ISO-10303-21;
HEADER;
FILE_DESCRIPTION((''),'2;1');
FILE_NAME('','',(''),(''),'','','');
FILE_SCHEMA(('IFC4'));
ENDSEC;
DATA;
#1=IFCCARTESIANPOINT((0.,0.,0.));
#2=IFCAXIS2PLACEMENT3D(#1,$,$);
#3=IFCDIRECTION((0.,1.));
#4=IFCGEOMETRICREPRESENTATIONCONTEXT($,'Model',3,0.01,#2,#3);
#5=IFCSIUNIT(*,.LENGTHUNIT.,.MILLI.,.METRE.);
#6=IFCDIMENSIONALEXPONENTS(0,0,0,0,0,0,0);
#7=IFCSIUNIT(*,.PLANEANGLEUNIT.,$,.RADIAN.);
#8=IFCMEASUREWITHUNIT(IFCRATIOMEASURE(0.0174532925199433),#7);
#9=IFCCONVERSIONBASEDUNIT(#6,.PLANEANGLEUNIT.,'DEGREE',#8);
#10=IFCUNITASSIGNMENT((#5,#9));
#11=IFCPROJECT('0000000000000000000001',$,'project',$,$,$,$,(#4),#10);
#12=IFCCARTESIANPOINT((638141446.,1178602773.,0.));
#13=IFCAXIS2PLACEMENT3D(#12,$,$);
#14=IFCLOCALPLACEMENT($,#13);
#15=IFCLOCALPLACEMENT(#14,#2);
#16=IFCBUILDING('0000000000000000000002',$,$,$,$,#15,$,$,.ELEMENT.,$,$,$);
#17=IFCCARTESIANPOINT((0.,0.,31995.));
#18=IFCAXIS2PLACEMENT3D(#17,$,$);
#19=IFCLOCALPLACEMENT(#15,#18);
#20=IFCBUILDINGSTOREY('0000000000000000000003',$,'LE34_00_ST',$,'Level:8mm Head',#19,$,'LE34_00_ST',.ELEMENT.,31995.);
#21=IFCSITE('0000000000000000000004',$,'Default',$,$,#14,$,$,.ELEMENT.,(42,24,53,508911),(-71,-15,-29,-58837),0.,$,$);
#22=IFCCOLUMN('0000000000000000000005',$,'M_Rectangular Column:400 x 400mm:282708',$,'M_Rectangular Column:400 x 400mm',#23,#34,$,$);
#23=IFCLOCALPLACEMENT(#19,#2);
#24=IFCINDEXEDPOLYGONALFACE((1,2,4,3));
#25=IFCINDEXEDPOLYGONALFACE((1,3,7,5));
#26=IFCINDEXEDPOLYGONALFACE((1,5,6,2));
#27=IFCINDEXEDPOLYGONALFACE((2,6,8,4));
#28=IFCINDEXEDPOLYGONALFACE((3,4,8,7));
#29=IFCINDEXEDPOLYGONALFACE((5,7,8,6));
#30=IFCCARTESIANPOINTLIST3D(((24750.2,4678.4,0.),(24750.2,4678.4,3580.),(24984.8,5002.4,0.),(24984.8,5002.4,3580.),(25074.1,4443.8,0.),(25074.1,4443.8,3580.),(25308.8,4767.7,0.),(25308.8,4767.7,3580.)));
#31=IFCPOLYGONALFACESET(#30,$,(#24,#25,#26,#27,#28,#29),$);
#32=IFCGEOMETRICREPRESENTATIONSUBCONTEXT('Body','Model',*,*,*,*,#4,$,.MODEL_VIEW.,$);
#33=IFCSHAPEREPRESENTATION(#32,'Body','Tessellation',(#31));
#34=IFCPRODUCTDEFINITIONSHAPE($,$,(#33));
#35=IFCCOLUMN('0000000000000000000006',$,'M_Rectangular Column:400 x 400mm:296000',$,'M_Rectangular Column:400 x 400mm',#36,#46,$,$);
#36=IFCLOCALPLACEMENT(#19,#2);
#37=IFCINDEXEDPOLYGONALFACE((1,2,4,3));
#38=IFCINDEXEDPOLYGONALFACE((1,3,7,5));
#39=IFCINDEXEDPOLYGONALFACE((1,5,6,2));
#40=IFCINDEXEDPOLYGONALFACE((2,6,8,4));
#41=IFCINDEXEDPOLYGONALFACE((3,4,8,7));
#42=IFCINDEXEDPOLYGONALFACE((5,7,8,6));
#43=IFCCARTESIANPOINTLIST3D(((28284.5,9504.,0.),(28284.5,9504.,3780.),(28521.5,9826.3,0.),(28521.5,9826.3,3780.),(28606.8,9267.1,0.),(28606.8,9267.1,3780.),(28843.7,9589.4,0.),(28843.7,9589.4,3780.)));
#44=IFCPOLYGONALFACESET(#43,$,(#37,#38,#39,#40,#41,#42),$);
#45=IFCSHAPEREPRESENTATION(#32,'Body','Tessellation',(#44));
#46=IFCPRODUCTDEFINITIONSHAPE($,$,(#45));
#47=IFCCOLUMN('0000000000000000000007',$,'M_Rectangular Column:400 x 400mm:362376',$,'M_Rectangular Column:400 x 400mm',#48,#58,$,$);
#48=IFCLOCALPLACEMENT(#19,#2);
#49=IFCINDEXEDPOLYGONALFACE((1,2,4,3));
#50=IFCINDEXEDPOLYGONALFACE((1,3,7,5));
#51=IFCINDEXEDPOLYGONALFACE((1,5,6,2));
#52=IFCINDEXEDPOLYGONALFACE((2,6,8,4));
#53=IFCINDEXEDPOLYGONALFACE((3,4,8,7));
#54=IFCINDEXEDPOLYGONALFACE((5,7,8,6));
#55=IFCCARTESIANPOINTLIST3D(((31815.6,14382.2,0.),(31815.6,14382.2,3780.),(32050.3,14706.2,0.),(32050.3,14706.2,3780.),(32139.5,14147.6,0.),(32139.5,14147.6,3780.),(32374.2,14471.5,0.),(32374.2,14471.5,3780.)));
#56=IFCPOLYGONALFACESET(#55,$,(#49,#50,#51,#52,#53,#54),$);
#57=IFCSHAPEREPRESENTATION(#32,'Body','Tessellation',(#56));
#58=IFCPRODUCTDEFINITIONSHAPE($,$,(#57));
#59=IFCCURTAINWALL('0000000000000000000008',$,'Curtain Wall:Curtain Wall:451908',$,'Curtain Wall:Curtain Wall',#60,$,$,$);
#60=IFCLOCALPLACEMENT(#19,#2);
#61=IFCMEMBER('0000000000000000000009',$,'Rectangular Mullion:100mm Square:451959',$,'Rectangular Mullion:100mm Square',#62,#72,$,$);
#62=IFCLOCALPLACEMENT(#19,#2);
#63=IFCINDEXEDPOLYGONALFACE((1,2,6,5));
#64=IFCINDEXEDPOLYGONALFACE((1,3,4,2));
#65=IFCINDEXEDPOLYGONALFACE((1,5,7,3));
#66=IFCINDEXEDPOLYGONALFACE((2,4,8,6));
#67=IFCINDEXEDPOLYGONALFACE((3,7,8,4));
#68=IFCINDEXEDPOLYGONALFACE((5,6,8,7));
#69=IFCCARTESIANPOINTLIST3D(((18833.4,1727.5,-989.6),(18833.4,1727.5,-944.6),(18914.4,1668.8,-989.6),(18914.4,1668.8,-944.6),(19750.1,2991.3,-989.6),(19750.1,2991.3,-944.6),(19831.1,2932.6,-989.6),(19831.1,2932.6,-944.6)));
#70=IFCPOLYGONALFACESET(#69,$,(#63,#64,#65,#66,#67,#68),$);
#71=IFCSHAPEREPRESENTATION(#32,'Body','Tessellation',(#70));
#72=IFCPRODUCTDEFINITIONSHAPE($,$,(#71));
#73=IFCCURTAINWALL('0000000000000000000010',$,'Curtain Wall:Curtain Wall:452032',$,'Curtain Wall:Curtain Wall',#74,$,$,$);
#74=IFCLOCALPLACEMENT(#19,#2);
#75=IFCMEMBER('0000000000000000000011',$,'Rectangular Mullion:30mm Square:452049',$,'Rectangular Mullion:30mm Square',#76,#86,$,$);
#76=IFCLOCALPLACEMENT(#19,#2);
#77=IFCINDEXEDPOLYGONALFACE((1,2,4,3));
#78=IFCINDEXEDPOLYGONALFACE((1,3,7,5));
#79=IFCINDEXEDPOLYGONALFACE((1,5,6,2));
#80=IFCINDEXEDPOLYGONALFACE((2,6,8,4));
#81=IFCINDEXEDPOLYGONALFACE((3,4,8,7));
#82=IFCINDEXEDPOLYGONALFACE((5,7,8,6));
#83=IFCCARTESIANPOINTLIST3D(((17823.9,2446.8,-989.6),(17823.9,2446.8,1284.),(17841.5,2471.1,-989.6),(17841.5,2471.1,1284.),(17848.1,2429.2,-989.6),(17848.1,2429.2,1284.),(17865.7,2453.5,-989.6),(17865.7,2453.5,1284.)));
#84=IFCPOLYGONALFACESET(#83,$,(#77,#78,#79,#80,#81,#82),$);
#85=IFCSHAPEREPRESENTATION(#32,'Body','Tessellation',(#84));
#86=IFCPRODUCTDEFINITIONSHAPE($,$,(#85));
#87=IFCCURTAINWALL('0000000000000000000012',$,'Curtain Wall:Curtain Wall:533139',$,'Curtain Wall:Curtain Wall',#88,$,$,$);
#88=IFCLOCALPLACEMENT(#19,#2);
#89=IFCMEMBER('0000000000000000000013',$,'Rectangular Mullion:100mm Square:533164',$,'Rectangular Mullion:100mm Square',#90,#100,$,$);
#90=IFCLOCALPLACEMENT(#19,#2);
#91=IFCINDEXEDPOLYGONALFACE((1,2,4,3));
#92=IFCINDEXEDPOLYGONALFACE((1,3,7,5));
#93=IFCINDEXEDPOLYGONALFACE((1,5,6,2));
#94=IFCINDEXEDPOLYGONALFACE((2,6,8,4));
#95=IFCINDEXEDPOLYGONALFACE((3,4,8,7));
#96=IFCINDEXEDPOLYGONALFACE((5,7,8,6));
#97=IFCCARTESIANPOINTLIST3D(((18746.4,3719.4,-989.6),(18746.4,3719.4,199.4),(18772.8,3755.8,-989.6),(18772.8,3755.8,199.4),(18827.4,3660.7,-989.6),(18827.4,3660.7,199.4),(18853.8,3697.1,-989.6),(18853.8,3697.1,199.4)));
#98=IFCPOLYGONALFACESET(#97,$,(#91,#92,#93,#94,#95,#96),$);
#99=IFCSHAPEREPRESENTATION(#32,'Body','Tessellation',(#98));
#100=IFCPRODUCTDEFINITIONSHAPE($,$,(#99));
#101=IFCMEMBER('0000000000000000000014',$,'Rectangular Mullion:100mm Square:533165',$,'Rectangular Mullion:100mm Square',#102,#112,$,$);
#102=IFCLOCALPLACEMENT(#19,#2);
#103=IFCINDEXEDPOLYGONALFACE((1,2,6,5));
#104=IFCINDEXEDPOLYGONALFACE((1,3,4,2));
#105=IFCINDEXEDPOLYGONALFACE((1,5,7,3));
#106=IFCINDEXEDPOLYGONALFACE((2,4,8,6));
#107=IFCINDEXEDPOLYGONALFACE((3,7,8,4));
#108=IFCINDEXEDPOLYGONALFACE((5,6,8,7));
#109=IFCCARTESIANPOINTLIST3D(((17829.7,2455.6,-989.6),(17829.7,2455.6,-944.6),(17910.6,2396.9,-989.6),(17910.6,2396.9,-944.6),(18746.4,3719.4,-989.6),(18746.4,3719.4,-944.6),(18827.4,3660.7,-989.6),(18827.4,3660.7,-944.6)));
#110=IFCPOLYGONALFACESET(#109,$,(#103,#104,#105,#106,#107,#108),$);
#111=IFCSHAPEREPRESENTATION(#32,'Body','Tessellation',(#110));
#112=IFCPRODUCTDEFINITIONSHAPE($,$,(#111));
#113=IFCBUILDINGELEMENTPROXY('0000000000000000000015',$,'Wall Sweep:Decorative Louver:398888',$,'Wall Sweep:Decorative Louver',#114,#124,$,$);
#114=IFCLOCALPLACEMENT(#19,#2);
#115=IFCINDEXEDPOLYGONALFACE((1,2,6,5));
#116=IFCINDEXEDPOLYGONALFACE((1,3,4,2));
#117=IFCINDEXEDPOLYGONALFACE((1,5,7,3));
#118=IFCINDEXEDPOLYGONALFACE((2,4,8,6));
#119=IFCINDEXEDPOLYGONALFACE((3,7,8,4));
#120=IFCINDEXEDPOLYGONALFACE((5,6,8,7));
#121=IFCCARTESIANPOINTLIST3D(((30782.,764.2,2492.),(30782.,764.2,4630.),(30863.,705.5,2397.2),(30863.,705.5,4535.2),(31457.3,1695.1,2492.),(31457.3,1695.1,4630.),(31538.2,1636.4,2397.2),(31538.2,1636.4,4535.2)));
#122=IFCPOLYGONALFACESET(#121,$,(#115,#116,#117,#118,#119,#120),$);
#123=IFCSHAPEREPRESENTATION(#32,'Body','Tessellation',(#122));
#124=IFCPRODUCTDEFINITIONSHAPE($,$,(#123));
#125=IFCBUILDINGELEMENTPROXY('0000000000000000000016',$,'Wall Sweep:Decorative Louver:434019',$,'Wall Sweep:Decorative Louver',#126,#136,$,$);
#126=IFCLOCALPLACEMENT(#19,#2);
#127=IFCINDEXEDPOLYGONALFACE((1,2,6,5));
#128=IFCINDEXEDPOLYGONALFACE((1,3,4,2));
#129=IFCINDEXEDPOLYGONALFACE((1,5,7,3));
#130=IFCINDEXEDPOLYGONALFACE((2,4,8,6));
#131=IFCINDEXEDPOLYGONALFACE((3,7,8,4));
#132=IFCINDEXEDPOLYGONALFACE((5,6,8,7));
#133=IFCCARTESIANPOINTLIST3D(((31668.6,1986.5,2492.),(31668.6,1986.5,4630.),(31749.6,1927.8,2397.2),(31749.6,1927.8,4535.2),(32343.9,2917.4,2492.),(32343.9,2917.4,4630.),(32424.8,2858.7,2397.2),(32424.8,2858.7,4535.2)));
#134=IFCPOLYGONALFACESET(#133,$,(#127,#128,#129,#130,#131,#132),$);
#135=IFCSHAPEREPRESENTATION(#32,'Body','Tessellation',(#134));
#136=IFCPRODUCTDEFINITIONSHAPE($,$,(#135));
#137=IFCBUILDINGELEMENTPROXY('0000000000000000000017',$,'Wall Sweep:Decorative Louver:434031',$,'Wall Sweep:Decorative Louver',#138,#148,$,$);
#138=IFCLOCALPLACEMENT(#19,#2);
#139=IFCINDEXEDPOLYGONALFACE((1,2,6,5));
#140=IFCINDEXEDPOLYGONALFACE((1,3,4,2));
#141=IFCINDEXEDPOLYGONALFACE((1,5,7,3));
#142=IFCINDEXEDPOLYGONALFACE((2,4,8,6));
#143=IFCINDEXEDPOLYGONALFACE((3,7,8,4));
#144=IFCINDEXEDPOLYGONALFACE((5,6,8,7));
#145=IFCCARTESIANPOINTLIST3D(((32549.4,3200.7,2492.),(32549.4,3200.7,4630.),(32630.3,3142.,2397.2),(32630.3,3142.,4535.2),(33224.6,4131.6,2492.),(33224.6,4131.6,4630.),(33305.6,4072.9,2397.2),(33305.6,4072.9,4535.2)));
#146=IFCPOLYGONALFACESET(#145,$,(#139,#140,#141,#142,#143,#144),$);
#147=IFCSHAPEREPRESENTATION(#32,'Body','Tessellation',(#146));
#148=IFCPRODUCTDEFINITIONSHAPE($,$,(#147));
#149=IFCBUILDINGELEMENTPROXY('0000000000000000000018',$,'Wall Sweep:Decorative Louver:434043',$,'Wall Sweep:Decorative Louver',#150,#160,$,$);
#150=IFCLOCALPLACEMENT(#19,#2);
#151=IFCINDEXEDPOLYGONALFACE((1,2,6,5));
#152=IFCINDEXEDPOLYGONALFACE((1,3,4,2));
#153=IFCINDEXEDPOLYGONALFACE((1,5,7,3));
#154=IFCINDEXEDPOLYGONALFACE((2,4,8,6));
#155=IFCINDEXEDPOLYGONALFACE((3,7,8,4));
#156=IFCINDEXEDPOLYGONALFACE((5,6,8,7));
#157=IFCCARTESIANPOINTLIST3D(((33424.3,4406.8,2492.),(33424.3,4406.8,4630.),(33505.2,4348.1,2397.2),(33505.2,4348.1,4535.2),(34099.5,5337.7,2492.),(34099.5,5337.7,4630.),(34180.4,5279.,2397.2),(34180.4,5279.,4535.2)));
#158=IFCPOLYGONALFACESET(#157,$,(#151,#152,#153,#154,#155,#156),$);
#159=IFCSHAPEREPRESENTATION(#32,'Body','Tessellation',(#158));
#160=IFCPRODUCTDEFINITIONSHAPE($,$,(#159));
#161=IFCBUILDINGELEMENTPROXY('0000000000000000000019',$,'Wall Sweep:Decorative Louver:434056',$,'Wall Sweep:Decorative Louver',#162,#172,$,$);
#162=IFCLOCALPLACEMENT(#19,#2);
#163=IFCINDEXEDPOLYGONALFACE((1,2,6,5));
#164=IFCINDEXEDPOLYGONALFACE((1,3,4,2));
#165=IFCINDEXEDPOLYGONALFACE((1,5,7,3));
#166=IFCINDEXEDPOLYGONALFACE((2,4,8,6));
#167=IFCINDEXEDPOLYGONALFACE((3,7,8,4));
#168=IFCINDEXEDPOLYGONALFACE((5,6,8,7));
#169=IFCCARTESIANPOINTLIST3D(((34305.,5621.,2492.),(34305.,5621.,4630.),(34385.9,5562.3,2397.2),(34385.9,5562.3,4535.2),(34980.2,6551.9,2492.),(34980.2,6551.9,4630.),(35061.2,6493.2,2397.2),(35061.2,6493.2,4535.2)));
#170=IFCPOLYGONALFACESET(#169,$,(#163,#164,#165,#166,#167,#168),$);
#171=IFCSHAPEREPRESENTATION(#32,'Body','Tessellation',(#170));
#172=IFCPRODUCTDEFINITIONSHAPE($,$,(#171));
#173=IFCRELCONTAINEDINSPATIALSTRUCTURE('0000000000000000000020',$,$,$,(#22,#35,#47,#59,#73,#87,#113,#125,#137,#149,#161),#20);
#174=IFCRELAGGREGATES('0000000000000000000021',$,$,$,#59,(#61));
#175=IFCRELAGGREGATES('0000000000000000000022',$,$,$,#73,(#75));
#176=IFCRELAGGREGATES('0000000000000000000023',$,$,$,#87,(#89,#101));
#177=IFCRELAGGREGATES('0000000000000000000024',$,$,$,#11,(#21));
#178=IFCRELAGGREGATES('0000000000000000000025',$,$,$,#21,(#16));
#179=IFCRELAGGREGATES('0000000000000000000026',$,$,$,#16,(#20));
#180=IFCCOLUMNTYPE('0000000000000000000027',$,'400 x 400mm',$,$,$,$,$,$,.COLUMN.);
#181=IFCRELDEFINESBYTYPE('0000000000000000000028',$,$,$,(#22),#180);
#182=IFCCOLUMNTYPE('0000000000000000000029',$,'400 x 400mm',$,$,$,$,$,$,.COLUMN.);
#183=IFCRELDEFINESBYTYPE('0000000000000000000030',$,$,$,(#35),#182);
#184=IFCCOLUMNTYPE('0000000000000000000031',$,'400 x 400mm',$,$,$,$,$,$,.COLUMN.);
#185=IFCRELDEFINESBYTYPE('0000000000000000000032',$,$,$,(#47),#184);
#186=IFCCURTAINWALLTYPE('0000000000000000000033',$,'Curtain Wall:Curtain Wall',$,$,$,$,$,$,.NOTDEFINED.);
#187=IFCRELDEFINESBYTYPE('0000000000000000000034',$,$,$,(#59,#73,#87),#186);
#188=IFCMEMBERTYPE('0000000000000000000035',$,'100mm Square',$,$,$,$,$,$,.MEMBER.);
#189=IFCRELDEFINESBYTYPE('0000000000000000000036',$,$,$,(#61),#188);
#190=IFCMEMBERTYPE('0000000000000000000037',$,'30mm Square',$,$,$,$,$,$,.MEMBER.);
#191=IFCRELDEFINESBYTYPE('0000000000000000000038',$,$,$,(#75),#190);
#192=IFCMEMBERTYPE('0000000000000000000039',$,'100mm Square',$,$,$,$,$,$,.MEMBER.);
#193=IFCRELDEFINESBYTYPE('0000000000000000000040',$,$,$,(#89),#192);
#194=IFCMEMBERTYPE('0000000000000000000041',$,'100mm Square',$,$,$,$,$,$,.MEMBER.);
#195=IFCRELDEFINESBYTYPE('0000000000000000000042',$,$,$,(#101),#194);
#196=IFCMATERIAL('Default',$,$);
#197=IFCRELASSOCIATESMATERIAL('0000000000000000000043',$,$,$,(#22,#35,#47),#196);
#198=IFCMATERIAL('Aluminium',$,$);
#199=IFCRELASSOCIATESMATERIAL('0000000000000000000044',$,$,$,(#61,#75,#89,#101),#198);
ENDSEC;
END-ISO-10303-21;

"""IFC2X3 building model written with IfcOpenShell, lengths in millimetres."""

from ifc_helpers import new_model, entity, si_unit, converted_unit, direction, frame, frame_2d, origin, origin_2d_with_axis, place, context, subcontext, project, spatial, polyline, rectangle, outline, extrude, source, transform, mapped, material, type_object, type_shapes, element, aggregate, save


model = new_model("IFC2X3")

# Units and contexts
model_context = context("Model", 3, precision=0.01, world=origin(), true_north=direction((0.0, 1.0)))
body_context = subcontext(model_context, "Body", "Model", "MODEL_VIEW")
ifc_project = project(units=[si_unit("LENGTHUNIT", "METRE", prefix="MILLI"), converted_unit("PLANEANGLEUNIT", "DEGREE", entity("IfcRatioMeasure", 0.0174532925199433), si_unit("PLANEANGLEUNIT", "RADIAN"), dimensions=[0, 0, 0, 0, 0, 0, 0])], contexts=[model_context])

# Site, building, storey
site_placement = place(None, frame((638141446.0, 1178602773.0, 0.0)))
site = spatial("IfcSite", under=ifc_project, at=site_placement, Name="Default", CompositionType="ELEMENT", RefLatitude=(42, 24, 53, 508911), RefLongitude=(-71, -15, -29, -58837), RefElevation=0.0)
building_placement = place(site_placement, origin())
building = spatial("IfcBuilding", under=site, at=building_placement, CompositionType="ELEMENT")
storey_placement = place(building_placement, frame((0.0, 0.0, 31995.0)))
storey = spatial("IfcBuildingStorey", under=building, at=storey_placement, Name="LE34_00_ST", ObjectType="Level:8mm Head", LongName="LE34_00_ST", CompositionType="ELEMENT", Elevation=31995.0)

# Columns
ifc_material_1 = material(Name="Default")
column_type_1 = type_object("IfcColumnType", Name="400 x 400mm", PredefinedType="COLUMN")
shared_shape_1 = source(origin(), body_context, "Body", "SweptSolid", [
    extrude(rectangle(XDim=400.0, YDim=400.0, at=frame_2d((0.0, 0.0), x_axis=(1.0, 0.0))), frame((25029.5, 4723.1, 31995.0), z_axis=(0.0, 0.0, 1.0), x_axis=(-0.809827, 0.586669, 0.0)), (0.0, 0.0, 1.0), 3580.0),
])
type_shapes(column_type_1, [shared_shape_1])
column_1_placement = place(storey_placement, frame((0.0, 0.0, -31995.0)))
element("IfcColumn", 1, at=column_1_placement, inside=storey, type_object=column_type_1, material=ifc_material_1, Name="M_Rectangular Column:400 x 400mm:282708", ObjectType="M_Rectangular Column:400 x 400mm", context=body_context, shape_type="MappedRepresentation", body=[
    mapped(shared_shape_1, transform((0.0, 0.0, 0.0), scale=1.0)),
])
column_type_2 = type_object("IfcColumnType", Name="400 x 400mm", PredefinedType="COLUMN")
shared_shape_2 = source(origin(), body_context, "Body", "SweptSolid", [
    extrude(rectangle(XDim=400.0, YDim=400.0, at=frame_2d((0.0, 0.0), x_axis=(1.0, 0.0))), frame((28564.1, 9546.7, 31995.0), z_axis=(0.0, 0.0, 1.0), x_axis=(-0.805709, 0.592312, 0.0)), (0.0, 0.0, 1.0), 3780.0),
])
type_shapes(column_type_2, [shared_shape_2])
column_2_placement = place(storey_placement, frame((0.0, 0.0, -31995.0)))
element("IfcColumn", 2, at=column_2_placement, inside=storey, type_object=column_type_2, material=ifc_material_1, Name="M_Rectangular Column:400 x 400mm:296000", ObjectType="M_Rectangular Column:400 x 400mm", context=body_context, shape_type="MappedRepresentation", body=[
    mapped(shared_shape_2, transform((0.0, 0.0, 0.0), scale=1.0)),
])
column_type_3 = type_object("IfcColumnType", Name="400 x 400mm", PredefinedType="COLUMN")
shared_shape_3 = source(origin(), body_context, "Body", "SweptSolid", [
    extrude(rectangle(XDim=400.0, YDim=400.0, at=frame_2d((0.0, 0.0), x_axis=(1.0, 0.0))), frame((32094.9, 14426.9, 31995.0), z_axis=(0.0, 0.0, 1.0), x_axis=(-0.809804, 0.5867, 0.0)), (0.0, 0.0, 1.0), 3780.0),
])
type_shapes(column_type_3, [shared_shape_3])
column_3_placement = place(storey_placement, frame((0.0, 0.0, -31995.0)))
element("IfcColumn", 3, at=column_3_placement, inside=storey, type_object=column_type_3, material=ifc_material_1, Name="M_Rectangular Column:400 x 400mm:362376", ObjectType="M_Rectangular Column:400 x 400mm", context=body_context, shape_type="MappedRepresentation", body=[
    mapped(shared_shape_3, transform((0.0, 0.0, 0.0), scale=1.0)),
])

# Curtain walls, members
curtain_wall_type = type_object("IfcCurtainWallType", Name="Curtain Wall:Curtain Wall", PredefinedType="NOTDEFINED")
curtain_wall_1_placement = place(storey_placement, frame((0.0, 0.0, -31995.0)))
curtain_wall_1 = element("IfcCurtainWall", 4, at=curtain_wall_1_placement, inside=storey, type_object=curtain_wall_type, Name="Curtain Wall:Curtain Wall:451908", ObjectType="Curtain Wall:Curtain Wall")
ifc_material_2 = material(Name="Aluminium")
member_type_1 = type_object("IfcMemberType", Name="100mm Square", PredefinedType="MEMBER")
shared_shape_4 = source(origin(), body_context, "Body", "SweptSolid", [
    extrude(rectangle(XDim=100.0, YDim=45.0, at=origin_2d_with_axis()), frame((-22.5, 0.0, -1561.3), z_axis=(0.0, 0.0, 1.0), x_axis=(0.0, -1.0, 0.0)), (0.0, 0.0, 1.0), 1561.3),
])
type_shapes(member_type_1, [shared_shape_4])
member_1_placement = place(storey_placement, frame((18873.9, 1698.1, -989.6), z_axis=(-0.587164, -0.809468, 0.0), x_axis=(0.0, 0.0, -1.0)))
member_1 = element("IfcMember", 5, at=member_1_placement, type_object=member_type_1, material=ifc_material_2, Name="Rectangular Mullion:100mm Square:451959", ObjectType="Rectangular Mullion:100mm Square", context=body_context, shape_type="MappedRepresentation", body=[
    mapped(shared_shape_4, transform((0.0, 0.0, 0.0), scale=1.0)),
])
aggregate(curtain_wall_1, [member_1])
curtain_wall_2_placement = place(storey_placement, frame((0.0, 0.0, -31995.0)))
curtain_wall_2 = element("IfcCurtainWall", 6, at=curtain_wall_2_placement, inside=storey, type_object=curtain_wall_type, Name="Curtain Wall:Curtain Wall:452032", ObjectType="Curtain Wall:Curtain Wall")
member_type_2 = type_object("IfcMemberType", Name="30mm Square", PredefinedType="MEMBER")
shared_shape_5 = source(origin(), body_context, "Body", "SweptSolid", [
    extrude(rectangle(XDim=30.0, YDim=30.0, at=origin_2d_with_axis()), frame((-15.0, 0.0, -2273.6), z_axis=(0.0, 0.0, 1.0), x_axis=(0.0, -1.0, 0.0)), (0.0, 0.0, 1.0), 2273.6),
])
type_shapes(member_type_2, [shared_shape_5])
member_2_placement = place(storey_placement, frame((17832.7, 2459.0, -989.6), z_axis=(0.0, 0.0, -1.0), x_axis=(-0.809468, 0.587164, 0.0)))
member_2 = element("IfcMember", 7, at=member_2_placement, type_object=member_type_2, material=ifc_material_2, Name="Rectangular Mullion:30mm Square:452049", ObjectType="Rectangular Mullion:30mm Square", context=body_context, shape_type="MappedRepresentation", body=[
    mapped(shared_shape_5, transform((0.0, 0.0, 0.0), scale=1.0)),
])

# Curtain wall, members
curtain_wall_3_placement = place(storey_placement, frame((0.0, 0.0, -31995.0)))
curtain_wall_3 = element("IfcCurtainWall", 8, at=curtain_wall_3_placement, inside=storey, type_object=curtain_wall_type, Name="Curtain Wall:Curtain Wall:533139", ObjectType="Curtain Wall:Curtain Wall")
member_type_3 = type_object("IfcMemberType", Name="100mm Square", PredefinedType="MEMBER")
shared_shape_6 = source(origin(), body_context, "Body", "SweptSolid", [
    extrude(rectangle(XDim=100.0, YDim=45.0, at=origin_2d_with_axis()), frame((-22.5, 0.0, -1189.0), z_axis=(0.0, 0.0, 1.0), x_axis=(0.0, -1.0, 0.0)), (0.0, 0.0, 1.0), 1189.0),
])
type_shapes(member_type_3, [shared_shape_6])
member_3_placement = place(storey_placement, frame((18813.3, 3726.5, -989.6), z_axis=(0.0, 0.0, -1.0), x_axis=(0.587164, 0.809468, 0.0)))
member_3 = element("IfcMember", 9, at=member_3_placement, type_object=member_type_3, material=ifc_material_2, Name="Rectangular Mullion:100mm Square:533164", ObjectType="Rectangular Mullion:100mm Square", context=body_context, shape_type="MappedRepresentation", body=[
    mapped(shared_shape_6, transform((0.0, 0.0, 0.0), scale=1.0)),
])
member_type_4 = type_object("IfcMemberType", Name="100mm Square", PredefinedType="MEMBER")
shared_shape_7 = source(origin(), body_context, "Body", "SweptSolid", [
    extrude(rectangle(XDim=100.0, YDim=45.0, at=origin_2d_with_axis()), frame((-22.5, 0.0, -1561.3), z_axis=(0.0, 0.0, 1.0), x_axis=(0.0, -1.0, 0.0)), (0.0, 0.0, 1.0), 1561.3),
])
type_shapes(member_type_4, [shared_shape_7])
member_4_placement = place(storey_placement, frame((17870.1, 2426.2, -989.6), z_axis=(-0.587164, -0.809468, 0.0), x_axis=(0.0, 0.0, -1.0)))
member_4 = element("IfcMember", 10, at=member_4_placement, type_object=member_type_4, material=ifc_material_2, Name="Rectangular Mullion:100mm Square:533165", ObjectType="Rectangular Mullion:100mm Square", context=body_context, shape_type="MappedRepresentation", body=[
    mapped(shared_shape_7, transform((0.0, 0.0, 0.0), scale=1.0)),
])

aggregate(curtain_wall_2, [member_2])
aggregate(curtain_wall_3, [member_3, member_4])

# Building element proxies
proxy_1_placement = place(storey_placement, origin())
element("IfcBuildingElementProxy", 11, at=proxy_1_placement, inside=storey, Name="Wall Sweep:Decorative Louver:398888", ObjectType="Wall Sweep:Decorative Louver", context=body_context, shape_type="SweptSolid", body=[
    extrude(outline(polyline([(-1021.6, -50.0), (1116.4, -50.0), (1021.6, 50.0), (-1116.4, 50.0), (-1021.6, -50.0)])), frame((30822.5, 734.9, 3513.6), z_axis=(0.587164, 0.809468, 0.0), x_axis=(0.0, 0.0, -1.0)), (0.0, 0.0, 1.0), 1150.0),
])
proxy_2_placement = place(storey_placement, origin())
element("IfcBuildingElementProxy", 12, at=proxy_2_placement, inside=storey, Name="Wall Sweep:Decorative Louver:434019", ObjectType="Wall Sweep:Decorative Louver", context=body_context, shape_type="SweptSolid", body=[
    extrude(outline(polyline([(-1021.6, -50.0), (1116.4, -50.0), (1021.6, 50.0), (-1116.4, 50.0), (-1021.6, -50.0)])), frame((31709.1, 1957.2, 3513.6), z_axis=(0.587164, 0.809468, 0.0), x_axis=(0.0, 0.0, -1.0)), (0.0, 0.0, 1.0), 1150.0),
])
proxy_3_placement = place(storey_placement, origin())
element("IfcBuildingElementProxy", 13, at=proxy_3_placement, inside=storey, Name="Wall Sweep:Decorative Louver:434031", ObjectType="Wall Sweep:Decorative Louver", context=body_context, shape_type="SweptSolid", body=[
    extrude(outline(polyline([(-1021.6, -50.0), (1116.4, -50.0), (1021.6, 50.0), (-1116.4, 50.0), (-1021.6, -50.0)])), frame((32589.9, 3171.4, 3513.6), z_axis=(0.587164, 0.809468, 0.0), x_axis=(0.0, 0.0, -1.0)), (0.0, 0.0, 1.0), 1150.0),
])
proxy_4_placement = place(storey_placement, origin())
element("IfcBuildingElementProxy", 14, at=proxy_4_placement, inside=storey, Name="Wall Sweep:Decorative Louver:434043", ObjectType="Wall Sweep:Decorative Louver", context=body_context, shape_type="SweptSolid", body=[
    extrude(outline(polyline([(-1021.6, -50.0), (1116.4, -50.0), (1021.6, 50.0), (-1116.4, 50.0), (-1021.6, -50.0)])), frame((33464.7, 4377.5, 3513.6), z_axis=(0.587164, 0.809468, 0.0), x_axis=(0.0, 0.0, -1.0)), (0.0, 0.0, 1.0), 1150.0),
])
proxy_5_placement = place(storey_placement, origin())
element("IfcBuildingElementProxy", 15, at=proxy_5_placement, inside=storey, Name="Wall Sweep:Decorative Louver:434056", ObjectType="Wall Sweep:Decorative Louver", context=body_context, shape_type="SweptSolid", body=[
    extrude(outline(polyline([(-1021.6, -50.0), (1116.4, -50.0), (1021.6, 50.0), (-1116.4, 50.0), (-1021.6, -50.0)])), frame((34345.5, 5591.7, 3513.6), z_axis=(0.587164, 0.809468, 0.0), x_axis=(0.0, 0.0, -1.0)), (0.0, 0.0, 1.0), 1150.0),
])

save(model, "model.ifc")
